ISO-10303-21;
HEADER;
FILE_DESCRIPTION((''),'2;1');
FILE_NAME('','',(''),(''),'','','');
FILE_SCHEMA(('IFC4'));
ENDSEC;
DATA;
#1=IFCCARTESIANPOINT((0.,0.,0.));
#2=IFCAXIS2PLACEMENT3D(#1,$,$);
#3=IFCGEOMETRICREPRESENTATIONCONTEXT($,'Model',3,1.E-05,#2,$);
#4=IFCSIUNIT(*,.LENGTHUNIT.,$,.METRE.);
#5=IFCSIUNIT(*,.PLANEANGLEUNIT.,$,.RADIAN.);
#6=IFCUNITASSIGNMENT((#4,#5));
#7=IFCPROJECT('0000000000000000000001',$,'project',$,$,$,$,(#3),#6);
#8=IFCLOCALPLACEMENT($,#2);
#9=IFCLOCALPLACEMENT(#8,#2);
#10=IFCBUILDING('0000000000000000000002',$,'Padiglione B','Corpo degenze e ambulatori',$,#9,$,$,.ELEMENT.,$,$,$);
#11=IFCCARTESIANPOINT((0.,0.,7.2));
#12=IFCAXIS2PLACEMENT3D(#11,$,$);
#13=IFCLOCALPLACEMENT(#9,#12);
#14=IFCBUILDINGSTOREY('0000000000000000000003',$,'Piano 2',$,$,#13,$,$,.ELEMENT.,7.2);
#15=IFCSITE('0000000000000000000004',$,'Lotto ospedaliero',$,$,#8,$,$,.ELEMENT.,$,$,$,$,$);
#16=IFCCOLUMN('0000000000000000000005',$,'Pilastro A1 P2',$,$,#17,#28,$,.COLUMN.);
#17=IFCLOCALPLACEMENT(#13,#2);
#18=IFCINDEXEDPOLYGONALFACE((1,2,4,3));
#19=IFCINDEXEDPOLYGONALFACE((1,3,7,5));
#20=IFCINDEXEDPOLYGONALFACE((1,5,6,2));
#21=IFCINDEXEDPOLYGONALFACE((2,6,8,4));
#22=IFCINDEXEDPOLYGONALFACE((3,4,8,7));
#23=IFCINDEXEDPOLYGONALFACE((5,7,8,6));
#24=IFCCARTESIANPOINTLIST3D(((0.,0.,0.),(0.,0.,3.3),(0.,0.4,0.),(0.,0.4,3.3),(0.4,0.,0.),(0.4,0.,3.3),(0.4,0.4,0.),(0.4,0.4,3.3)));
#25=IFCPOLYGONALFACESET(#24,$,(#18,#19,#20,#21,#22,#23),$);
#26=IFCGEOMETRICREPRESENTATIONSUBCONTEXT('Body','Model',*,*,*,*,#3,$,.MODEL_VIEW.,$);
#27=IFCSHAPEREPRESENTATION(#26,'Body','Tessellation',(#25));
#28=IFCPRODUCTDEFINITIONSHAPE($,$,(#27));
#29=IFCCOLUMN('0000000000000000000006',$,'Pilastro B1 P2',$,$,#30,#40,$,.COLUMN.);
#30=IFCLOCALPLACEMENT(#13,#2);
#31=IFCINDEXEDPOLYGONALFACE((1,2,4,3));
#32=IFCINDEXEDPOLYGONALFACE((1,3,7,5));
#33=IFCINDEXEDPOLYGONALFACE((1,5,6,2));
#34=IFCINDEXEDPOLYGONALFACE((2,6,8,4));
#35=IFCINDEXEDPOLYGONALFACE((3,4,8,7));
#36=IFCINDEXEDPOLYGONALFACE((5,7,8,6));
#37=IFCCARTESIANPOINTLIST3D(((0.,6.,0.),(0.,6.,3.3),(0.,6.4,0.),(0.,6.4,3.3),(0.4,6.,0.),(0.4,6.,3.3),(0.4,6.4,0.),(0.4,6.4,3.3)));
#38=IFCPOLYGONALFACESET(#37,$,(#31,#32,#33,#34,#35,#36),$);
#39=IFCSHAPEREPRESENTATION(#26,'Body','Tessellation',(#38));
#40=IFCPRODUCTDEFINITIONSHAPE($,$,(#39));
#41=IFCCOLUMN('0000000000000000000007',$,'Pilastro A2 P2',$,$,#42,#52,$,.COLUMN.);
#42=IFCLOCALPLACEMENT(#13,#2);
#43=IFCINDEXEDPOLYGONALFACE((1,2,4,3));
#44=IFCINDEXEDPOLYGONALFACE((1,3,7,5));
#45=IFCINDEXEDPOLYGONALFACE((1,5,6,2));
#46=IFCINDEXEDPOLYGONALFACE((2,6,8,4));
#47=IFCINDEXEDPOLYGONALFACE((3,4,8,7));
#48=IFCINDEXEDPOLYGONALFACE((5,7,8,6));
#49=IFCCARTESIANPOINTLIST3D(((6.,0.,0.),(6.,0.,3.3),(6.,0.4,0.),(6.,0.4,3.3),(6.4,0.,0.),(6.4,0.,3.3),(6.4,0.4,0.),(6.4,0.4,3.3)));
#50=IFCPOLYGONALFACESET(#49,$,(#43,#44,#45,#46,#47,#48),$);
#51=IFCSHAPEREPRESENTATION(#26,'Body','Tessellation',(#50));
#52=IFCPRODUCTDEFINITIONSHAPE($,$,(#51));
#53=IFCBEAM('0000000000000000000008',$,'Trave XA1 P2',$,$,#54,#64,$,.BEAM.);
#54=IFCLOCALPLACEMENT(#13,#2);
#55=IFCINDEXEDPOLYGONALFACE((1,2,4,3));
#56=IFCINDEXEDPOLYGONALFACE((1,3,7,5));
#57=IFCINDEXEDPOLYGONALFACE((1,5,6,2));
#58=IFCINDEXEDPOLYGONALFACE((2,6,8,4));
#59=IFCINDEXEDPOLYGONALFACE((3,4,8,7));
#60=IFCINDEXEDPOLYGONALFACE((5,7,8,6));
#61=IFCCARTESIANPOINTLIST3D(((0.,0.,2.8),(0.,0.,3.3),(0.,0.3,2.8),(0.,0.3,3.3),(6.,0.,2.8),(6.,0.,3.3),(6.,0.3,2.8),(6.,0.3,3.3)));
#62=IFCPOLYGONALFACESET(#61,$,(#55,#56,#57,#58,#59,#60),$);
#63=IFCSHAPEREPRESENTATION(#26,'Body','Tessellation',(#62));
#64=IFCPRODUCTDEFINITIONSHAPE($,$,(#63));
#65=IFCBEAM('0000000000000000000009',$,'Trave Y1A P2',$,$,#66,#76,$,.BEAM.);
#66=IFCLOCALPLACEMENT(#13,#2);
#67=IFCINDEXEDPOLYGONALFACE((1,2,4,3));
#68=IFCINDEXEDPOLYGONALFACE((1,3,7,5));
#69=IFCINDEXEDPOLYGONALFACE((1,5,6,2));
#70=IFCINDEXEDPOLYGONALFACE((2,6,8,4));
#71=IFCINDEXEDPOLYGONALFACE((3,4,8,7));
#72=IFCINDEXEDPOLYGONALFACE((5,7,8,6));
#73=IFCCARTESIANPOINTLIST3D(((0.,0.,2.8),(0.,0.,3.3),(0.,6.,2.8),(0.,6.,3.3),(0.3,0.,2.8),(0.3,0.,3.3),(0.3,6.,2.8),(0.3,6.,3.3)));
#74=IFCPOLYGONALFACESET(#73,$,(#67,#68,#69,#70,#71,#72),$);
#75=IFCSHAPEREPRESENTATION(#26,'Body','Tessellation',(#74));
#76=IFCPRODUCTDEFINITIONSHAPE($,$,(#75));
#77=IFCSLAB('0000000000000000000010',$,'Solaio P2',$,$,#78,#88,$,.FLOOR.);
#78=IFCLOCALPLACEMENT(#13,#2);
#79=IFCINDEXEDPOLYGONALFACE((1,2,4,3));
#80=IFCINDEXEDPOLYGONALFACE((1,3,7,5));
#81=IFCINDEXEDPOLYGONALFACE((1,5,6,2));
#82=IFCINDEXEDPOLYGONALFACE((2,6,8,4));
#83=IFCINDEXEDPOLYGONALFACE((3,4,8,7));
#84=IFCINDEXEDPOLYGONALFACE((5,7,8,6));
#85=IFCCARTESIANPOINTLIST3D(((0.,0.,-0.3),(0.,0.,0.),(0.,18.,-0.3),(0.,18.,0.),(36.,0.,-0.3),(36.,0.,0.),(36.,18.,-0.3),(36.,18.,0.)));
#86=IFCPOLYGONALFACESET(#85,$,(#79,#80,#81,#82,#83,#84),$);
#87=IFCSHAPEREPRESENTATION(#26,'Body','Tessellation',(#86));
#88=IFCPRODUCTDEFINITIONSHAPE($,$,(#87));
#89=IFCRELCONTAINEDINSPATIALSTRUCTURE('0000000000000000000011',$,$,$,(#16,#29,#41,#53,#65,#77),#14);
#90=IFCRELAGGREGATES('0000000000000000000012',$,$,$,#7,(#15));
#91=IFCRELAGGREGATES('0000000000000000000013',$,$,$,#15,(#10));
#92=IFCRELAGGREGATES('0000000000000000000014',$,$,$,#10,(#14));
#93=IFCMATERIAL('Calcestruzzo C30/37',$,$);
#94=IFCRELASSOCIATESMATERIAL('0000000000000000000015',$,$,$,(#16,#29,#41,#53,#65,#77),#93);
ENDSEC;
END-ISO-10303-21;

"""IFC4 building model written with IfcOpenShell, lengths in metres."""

from ifc_helpers import new_model, si_unit, frame, frame_2d, origin, place, context, subcontext, project, spatial, rectangle, extrude, material, element, save


model = new_model("IFC4")

# Units and contexts
model_context = context("Model", 3, precision=1e-05, world=origin())
body_context = subcontext(model_context, "Body", "Model", "MODEL_VIEW")
ifc_project = project(units=[si_unit("LENGTHUNIT", "METRE"), si_unit("PLANEANGLEUNIT", "RADIAN")], contexts=[model_context])

# Site, building, storey
site_placement = place(None, origin())
site = spatial("IfcSite", under=ifc_project, at=site_placement, Name="Lotto ospedaliero", CompositionType="ELEMENT")
building_placement = place(site_placement, origin())
building = spatial("IfcBuilding", under=site, at=building_placement, Name="Padiglione B", Description="Corpo degenze e ambulatori", CompositionType="ELEMENT")
storey_placement = place(building_placement, frame((0.0, 0.0, 7.2)))
storey = spatial("IfcBuildingStorey", under=building, at=storey_placement, Name="Piano 2", CompositionType="ELEMENT", Elevation=7.2)

# Columns
ifc_material_1 = material(Name="Calcestruzzo C30/37")
for number, where, name in (
    (1, (0.0, 0.0, 0.0), "Pilastro A1 P2"),
    (2, (0.0, 6.0, 0.0), "Pilastro B1 P2"),
    (3, (6.0, 0.0, 0.0), "Pilastro A2 P2"),
):
    element("IfcColumn", number, at=place(storey_placement, frame(where)), inside=storey, material=ifc_material_1, Name=name, PredefinedType="COLUMN", context=body_context, shape_type="SweptSolid", body=[
        extrude(rectangle(XDim=0.4, YDim=0.4, at=frame_2d((0.2, 0.2))), origin(), (0.0, 0.0, 1.0), 3.3),
    ])

# Beams
beam_1_placement = place(storey_placement, frame((0.0, 0.0, 2.8)))
element("IfcBeam", 4, at=beam_1_placement, inside=storey, material=ifc_material_1, Name="Trave XA1 P2", PredefinedType="BEAM", context=body_context, shape_type="SweptSolid", body=[
    extrude(rectangle(XDim=6.0, YDim=0.3, at=frame_2d((3.0, 0.15))), origin(), (0.0, 0.0, 1.0), 0.5),
])
beam_2_placement = place(storey_placement, frame((0.0, 0.0, 2.8)))
element("IfcBeam", 5, at=beam_2_placement, inside=storey, material=ifc_material_1, Name="Trave Y1A P2", PredefinedType="BEAM", context=body_context, shape_type="SweptSolid", body=[
    extrude(rectangle(XDim=0.3, YDim=6.0, at=frame_2d((0.15, 3.0))), origin(), (0.0, 0.0, 1.0), 0.5),
])

# Slab
slab_placement = place(storey_placement, frame((0.0, 0.0, -0.3)))
element("IfcSlab", 6, at=slab_placement, inside=storey, material=ifc_material_1, Name="Solaio P2", PredefinedType="FLOOR", context=body_context, shape_type="SweptSolid", body=[
    extrude(rectangle(XDim=36.0, YDim=18.0, at=frame_2d((18.0, 9.0))), origin(), (0.0, 0.0, 1.0), 0.3),
])

save(model, "model.ifc")
